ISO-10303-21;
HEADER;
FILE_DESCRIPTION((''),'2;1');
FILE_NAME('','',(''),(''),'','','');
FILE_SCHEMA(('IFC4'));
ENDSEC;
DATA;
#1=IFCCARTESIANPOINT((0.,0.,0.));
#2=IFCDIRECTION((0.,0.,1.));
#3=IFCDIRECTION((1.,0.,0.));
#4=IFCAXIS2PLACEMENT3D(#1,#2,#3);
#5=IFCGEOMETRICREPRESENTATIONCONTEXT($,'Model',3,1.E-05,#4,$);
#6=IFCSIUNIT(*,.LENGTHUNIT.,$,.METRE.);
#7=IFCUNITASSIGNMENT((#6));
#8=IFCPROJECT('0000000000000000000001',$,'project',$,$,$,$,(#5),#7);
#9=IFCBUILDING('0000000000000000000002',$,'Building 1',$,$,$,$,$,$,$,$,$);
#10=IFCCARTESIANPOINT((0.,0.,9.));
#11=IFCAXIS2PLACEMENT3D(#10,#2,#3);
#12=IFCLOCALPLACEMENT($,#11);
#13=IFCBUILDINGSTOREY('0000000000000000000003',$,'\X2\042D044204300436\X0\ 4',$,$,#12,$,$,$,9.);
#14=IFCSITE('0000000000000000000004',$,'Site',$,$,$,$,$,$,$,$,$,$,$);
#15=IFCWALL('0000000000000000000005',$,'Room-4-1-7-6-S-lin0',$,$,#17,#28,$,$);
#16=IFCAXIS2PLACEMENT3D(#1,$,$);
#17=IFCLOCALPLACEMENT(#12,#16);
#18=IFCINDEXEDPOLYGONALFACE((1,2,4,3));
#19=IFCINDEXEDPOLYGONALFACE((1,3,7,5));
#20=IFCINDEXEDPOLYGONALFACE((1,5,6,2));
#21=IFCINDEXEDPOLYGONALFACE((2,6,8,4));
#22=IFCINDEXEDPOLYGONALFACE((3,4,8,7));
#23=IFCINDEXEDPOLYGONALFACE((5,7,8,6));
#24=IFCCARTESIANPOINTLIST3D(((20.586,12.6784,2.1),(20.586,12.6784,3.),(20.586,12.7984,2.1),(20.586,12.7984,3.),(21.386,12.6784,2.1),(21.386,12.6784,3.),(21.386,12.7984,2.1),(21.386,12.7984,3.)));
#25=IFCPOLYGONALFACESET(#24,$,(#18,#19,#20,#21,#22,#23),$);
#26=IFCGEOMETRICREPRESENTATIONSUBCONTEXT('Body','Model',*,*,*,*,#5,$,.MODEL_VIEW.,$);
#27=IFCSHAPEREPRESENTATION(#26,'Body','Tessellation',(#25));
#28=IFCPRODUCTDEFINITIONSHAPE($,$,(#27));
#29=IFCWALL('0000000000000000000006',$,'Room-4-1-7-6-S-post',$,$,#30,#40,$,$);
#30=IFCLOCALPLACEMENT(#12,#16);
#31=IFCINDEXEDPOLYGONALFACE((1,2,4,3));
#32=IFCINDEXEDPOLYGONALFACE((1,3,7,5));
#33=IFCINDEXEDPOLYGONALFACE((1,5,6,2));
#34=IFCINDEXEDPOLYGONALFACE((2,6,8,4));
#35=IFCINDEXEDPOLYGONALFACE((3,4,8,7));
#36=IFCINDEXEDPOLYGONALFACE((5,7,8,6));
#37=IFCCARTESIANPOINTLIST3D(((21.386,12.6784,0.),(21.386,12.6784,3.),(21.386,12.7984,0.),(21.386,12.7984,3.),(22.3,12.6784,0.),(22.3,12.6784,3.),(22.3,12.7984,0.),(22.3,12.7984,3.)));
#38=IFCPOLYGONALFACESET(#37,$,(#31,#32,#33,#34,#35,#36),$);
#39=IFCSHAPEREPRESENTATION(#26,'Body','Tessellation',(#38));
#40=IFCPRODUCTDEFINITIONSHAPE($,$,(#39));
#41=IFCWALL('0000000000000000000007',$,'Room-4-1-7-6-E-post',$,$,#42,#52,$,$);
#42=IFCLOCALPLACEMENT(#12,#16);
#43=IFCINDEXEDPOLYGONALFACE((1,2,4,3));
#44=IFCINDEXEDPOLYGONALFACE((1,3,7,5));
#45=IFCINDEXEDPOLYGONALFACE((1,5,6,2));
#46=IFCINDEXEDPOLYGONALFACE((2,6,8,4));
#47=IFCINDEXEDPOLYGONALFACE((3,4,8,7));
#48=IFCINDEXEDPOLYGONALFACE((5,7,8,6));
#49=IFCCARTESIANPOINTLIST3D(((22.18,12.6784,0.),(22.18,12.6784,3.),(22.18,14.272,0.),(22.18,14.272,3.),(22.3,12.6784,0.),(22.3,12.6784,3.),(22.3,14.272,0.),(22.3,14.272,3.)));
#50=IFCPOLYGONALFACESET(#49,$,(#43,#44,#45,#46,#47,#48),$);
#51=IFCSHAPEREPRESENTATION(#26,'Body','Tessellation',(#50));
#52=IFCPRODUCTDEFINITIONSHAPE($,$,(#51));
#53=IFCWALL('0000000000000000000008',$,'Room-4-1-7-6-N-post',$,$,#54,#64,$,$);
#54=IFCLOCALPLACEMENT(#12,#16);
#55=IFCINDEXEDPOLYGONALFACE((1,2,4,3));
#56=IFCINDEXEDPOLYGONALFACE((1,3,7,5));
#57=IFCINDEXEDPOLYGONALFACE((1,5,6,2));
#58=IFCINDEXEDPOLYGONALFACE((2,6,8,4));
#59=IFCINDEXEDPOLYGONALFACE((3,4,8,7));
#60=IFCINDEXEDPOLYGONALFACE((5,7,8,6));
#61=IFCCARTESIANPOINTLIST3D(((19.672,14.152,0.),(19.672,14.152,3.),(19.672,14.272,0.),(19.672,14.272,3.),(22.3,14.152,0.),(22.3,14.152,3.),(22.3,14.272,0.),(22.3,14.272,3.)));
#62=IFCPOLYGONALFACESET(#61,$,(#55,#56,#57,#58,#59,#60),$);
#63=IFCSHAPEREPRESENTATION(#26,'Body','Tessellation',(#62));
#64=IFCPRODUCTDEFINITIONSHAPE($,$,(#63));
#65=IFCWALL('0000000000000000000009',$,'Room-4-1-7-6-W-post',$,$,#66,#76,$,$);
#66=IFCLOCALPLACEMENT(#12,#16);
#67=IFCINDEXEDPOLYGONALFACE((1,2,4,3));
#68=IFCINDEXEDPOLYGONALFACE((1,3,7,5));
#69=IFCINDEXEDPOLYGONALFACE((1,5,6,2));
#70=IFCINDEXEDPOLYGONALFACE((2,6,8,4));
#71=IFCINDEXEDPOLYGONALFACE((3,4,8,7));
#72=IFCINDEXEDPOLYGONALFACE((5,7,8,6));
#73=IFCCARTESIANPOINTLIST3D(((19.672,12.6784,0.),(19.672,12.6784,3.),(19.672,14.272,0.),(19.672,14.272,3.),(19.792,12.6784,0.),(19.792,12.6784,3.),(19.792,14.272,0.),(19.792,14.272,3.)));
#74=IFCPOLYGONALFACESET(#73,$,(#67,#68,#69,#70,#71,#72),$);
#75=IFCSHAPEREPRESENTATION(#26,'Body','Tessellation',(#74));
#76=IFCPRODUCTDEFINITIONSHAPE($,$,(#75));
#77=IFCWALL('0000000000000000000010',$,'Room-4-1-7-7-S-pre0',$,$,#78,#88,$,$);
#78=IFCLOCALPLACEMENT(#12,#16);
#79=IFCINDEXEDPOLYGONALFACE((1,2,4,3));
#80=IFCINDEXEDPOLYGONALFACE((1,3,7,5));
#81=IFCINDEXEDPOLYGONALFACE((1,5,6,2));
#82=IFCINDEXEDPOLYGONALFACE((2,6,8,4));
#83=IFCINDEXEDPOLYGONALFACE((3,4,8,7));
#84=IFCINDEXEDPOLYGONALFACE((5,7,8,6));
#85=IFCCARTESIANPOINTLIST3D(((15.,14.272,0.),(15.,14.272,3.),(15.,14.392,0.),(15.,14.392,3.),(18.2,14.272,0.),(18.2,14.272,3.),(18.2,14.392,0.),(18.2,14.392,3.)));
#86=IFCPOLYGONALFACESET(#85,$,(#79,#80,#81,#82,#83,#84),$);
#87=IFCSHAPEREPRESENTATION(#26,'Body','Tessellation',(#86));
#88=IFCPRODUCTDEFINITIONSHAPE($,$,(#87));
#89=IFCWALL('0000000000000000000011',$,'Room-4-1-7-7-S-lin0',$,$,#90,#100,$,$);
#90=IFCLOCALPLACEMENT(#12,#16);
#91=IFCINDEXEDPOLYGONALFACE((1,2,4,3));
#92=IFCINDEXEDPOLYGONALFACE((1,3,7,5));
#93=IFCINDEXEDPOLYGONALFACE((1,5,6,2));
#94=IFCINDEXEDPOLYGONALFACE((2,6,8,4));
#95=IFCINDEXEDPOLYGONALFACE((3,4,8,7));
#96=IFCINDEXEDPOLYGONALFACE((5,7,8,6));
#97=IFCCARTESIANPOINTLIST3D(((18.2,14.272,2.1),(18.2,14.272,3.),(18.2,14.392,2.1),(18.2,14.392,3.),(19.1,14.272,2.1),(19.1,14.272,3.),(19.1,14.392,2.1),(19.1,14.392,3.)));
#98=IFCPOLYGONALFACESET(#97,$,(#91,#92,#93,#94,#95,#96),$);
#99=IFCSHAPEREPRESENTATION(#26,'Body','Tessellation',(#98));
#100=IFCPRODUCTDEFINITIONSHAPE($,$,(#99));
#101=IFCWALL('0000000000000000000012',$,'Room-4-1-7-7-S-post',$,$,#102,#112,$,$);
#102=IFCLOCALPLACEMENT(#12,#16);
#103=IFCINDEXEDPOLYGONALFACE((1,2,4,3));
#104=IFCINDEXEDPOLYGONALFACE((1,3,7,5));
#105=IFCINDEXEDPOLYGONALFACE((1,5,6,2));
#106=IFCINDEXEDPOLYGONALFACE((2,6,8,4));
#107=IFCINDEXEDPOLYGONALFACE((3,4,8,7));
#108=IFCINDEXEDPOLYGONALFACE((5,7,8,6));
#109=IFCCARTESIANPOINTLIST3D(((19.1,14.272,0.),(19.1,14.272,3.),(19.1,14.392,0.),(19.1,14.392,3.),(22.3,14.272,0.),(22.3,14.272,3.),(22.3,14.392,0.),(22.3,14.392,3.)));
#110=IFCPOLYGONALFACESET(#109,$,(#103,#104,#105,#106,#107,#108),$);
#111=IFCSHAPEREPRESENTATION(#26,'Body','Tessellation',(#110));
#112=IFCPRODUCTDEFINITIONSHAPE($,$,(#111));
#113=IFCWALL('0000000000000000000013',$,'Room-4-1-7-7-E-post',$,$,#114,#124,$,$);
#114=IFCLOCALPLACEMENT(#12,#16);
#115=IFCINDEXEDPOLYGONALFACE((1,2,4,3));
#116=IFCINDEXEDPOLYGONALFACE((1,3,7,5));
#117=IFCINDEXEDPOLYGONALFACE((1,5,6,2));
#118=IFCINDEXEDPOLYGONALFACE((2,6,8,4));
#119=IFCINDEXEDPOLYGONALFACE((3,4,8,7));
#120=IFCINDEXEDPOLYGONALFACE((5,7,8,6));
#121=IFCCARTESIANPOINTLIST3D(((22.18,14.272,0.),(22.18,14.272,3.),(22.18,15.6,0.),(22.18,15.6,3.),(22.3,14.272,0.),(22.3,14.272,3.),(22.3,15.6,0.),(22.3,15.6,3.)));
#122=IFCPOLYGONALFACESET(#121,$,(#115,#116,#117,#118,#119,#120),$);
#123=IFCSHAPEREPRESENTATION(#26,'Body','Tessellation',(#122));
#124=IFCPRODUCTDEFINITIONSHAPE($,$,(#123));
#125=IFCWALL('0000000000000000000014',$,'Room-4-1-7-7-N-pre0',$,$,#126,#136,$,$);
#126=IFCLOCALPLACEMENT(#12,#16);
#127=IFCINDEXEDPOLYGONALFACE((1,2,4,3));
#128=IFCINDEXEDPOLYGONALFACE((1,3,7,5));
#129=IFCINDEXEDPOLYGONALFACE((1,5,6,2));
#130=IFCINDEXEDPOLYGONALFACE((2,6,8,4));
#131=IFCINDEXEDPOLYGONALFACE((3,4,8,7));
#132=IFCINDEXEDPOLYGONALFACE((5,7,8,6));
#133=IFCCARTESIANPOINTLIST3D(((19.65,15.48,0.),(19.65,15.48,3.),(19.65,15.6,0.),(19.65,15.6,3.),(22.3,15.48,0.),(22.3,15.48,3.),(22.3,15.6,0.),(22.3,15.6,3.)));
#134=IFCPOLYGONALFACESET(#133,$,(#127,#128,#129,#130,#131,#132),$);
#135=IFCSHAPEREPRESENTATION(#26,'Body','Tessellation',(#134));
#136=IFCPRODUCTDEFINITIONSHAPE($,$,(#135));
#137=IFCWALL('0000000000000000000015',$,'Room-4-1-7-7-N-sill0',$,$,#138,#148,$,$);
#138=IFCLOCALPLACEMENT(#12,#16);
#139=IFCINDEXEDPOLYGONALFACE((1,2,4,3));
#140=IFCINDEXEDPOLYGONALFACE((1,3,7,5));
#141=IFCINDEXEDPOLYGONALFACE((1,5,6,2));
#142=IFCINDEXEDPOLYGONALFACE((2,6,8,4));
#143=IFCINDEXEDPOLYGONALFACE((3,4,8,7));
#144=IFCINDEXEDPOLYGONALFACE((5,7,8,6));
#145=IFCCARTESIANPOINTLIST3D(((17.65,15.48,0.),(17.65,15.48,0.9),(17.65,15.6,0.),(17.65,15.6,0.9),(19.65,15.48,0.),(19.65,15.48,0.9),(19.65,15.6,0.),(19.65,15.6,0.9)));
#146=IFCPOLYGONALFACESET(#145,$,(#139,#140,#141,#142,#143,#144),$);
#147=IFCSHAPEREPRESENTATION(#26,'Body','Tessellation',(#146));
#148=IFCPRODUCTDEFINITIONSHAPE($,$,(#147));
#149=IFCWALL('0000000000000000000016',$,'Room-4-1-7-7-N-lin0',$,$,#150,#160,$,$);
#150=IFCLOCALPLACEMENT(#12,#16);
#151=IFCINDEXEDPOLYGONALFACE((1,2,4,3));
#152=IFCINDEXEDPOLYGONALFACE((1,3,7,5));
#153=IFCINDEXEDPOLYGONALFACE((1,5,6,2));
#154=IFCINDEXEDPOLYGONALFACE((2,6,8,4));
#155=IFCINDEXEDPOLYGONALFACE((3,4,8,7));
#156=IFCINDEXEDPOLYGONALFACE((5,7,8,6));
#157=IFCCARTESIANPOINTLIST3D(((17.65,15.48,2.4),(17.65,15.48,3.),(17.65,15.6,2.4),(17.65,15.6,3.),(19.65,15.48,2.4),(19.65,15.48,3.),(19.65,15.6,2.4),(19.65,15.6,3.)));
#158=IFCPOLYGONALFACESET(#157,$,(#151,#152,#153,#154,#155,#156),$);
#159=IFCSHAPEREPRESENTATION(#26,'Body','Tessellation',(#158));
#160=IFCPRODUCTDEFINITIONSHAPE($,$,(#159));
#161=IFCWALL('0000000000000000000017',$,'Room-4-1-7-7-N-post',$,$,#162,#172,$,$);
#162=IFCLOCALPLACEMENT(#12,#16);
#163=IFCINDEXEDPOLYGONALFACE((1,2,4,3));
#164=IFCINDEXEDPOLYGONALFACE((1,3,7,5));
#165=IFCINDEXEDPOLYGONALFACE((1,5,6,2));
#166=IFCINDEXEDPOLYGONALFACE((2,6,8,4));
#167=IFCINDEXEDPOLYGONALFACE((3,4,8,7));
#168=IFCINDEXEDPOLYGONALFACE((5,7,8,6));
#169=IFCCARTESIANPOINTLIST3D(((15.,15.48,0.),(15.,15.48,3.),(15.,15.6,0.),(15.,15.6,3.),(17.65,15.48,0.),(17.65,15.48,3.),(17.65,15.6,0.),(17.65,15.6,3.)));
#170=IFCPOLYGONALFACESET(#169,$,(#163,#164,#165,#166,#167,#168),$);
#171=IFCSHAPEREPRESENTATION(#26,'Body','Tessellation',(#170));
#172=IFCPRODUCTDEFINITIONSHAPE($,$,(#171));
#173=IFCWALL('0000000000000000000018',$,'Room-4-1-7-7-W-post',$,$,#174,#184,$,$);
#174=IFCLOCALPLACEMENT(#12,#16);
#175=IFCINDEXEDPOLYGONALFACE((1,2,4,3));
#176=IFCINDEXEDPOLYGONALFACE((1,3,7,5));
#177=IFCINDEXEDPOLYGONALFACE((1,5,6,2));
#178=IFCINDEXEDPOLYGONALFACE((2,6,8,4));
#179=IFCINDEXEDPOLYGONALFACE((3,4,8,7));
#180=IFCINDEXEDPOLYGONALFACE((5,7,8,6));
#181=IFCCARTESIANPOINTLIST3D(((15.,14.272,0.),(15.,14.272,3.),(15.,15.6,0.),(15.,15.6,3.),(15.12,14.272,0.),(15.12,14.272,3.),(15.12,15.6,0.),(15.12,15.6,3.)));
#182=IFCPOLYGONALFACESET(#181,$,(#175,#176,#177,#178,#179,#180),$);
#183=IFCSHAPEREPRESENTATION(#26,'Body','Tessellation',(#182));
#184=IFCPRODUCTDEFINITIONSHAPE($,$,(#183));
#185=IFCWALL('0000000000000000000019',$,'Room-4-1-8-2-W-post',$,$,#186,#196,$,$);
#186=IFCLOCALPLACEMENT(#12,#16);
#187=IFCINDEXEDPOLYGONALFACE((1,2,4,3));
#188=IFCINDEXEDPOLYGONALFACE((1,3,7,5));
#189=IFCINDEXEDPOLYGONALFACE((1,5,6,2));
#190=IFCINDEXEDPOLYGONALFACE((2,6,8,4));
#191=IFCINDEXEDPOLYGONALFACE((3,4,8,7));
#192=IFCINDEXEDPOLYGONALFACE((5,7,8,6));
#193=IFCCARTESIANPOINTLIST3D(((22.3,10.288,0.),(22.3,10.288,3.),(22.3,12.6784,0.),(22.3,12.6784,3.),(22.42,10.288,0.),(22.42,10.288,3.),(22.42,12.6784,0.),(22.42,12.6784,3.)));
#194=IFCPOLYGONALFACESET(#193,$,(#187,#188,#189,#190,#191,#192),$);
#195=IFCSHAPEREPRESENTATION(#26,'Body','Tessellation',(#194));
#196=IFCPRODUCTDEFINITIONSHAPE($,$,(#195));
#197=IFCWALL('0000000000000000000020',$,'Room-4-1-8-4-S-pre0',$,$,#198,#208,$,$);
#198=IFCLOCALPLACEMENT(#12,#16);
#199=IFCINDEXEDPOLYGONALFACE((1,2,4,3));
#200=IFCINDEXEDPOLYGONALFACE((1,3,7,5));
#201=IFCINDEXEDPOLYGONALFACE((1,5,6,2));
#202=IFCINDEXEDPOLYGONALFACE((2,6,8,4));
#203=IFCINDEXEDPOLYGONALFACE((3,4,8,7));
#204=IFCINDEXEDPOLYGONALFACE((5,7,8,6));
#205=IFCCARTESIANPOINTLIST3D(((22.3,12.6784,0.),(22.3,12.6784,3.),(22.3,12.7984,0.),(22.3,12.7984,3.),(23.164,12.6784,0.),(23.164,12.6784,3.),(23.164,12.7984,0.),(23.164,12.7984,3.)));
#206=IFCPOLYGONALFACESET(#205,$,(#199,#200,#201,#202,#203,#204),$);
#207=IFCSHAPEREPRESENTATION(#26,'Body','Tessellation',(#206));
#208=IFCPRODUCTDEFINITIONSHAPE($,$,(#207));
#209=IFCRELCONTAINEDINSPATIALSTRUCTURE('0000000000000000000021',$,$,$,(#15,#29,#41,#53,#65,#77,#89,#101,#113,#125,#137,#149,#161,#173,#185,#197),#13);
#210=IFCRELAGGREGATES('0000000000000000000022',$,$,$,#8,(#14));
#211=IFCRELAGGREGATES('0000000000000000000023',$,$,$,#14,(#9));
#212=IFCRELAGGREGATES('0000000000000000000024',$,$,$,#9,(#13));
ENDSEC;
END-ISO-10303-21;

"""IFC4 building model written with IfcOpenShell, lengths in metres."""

from ifc_helpers import new_model, si_unit, frame, origin_with_axes, place, context, subcontext, project, spatial, indexed_curve, outline, extrude, element, save


model = new_model("IFC4")

# Units and contexts
model_context = context("Model", 3, precision=1e-05, world=origin_with_axes())
body_context = subcontext(model_context, "Body", "Model", "MODEL_VIEW")
ifc_project = project(units=[si_unit("LENGTHUNIT", "METRE")], contexts=[model_context])

# Site, building, storey
site = spatial("IfcSite", under=ifc_project, Name="Site")
building = spatial("IfcBuilding", under=site, Name="Building 1")
storey_placement = place(None, frame((0.0, 0.0, 9.0), z_axis=(0.0, 0.0, 1.0), x_axis=(1.0, 0.0, 0.0)))
storey = spatial("IfcBuildingStorey", under=building, at=storey_placement, Name="Этаж 4", Elevation=9.0)

# Walls
wall_1_placement = place(storey_placement, frame((20.586, 12.6784, 2.1), z_axis=(0.0, 0.0, 1.0), x_axis=(1.0, 0.0, 0.0)))
element("IfcWall", 1, at=wall_1_placement, inside=storey, Name="Room-4-1-7-6-S-lin0", context=body_context, shape_type="SweptSolid", body=[
    extrude(outline(indexed_curve([(0.0, 0.0), (0.0, 0.12), (0.8, 0.12), (0.8, 0.0), (0.0, 0.0)], self_intersect=False)), origin_with_axes(), (0.0, 0.0, 1.0), 0.9),
])
wall_2_placement = place(storey_placement, frame((21.386, 12.6784, 0.0), z_axis=(0.0, 0.0, 1.0), x_axis=(1.0, 0.0, 0.0)))
element("IfcWall", 2, at=wall_2_placement, inside=storey, Name="Room-4-1-7-6-S-post", context=body_context, shape_type="SweptSolid", body=[
    extrude(outline(indexed_curve([(0.0, 0.0), (0.0, 0.12), (0.914, 0.12), (0.914, 0.0), (0.0, 0.0)], self_intersect=False)), origin_with_axes(), (0.0, 0.0, 1.0), 3.0),
])
wall_3_placement = place(storey_placement, frame((22.3, 12.6784, 0.0), z_axis=(0.0, 0.0, 1.0), x_axis=(0.0, 1.0, 0.0)))
element("IfcWall", 3, at=wall_3_placement, inside=storey, Name="Room-4-1-7-6-E-post", context=body_context, shape_type="SweptSolid", body=[
    extrude(outline(indexed_curve([(0.0, 0.0), (0.0, 0.12), (1.5936, 0.12), (1.5936, 0.0), (0.0, 0.0)], self_intersect=False)), origin_with_axes(), (0.0, 0.0, 1.0), 3.0),
])
wall_4_placement = place(storey_placement, frame((22.3, 14.272, 0.0), z_axis=(0.0, 0.0, 1.0), x_axis=(-1.0, 0.0, 0.0)))
element("IfcWall", 4, at=wall_4_placement, inside=storey, Name="Room-4-1-7-6-N-post", context=body_context, shape_type="SweptSolid", body=[
    extrude(outline(indexed_curve([(0.0, 0.0), (0.0, 0.12), (2.628, 0.12), (2.628, 0.0), (0.0, 0.0)], self_intersect=False)), origin_with_axes(), (0.0, 0.0, 1.0), 3.0),
])
wall_5_placement = place(storey_placement, frame((19.672, 14.272, 0.0), z_axis=(0.0, 0.0, 1.0), x_axis=(0.0, -1.0, 0.0)))
element("IfcWall", 5, at=wall_5_placement, inside=storey, Name="Room-4-1-7-6-W-post", context=body_context, shape_type="SweptSolid", body=[
    extrude(outline(indexed_curve([(0.0, 0.0), (0.0, 0.12), (1.5936, 0.12), (1.5936, 0.0), (0.0, 0.0)], self_intersect=False)), origin_with_axes(), (0.0, 0.0, 1.0), 3.0),
])
wall_6_placement = place(storey_placement, frame((15.0, 14.272, 0.0), z_axis=(0.0, 0.0, 1.0), x_axis=(1.0, 0.0, 0.0)))
element("IfcWall", 6, at=wall_6_placement, inside=storey, Name="Room-4-1-7-7-S-pre0", context=body_context, shape_type="SweptSolid", body=[
    extrude(outline(indexed_curve([(0.0, 0.0), (0.0, 0.12), (3.2, 0.12), (3.2, 0.0), (0.0, 0.0)], self_intersect=False)), origin_with_axes(), (0.0, 0.0, 1.0), 3.0),
])
wall_7_placement = place(storey_placement, frame((18.2, 14.272, 2.1), z_axis=(0.0, 0.0, 1.0), x_axis=(1.0, 0.0, 0.0)))
element("IfcWall", 7, at=wall_7_placement, inside=storey, Name="Room-4-1-7-7-S-lin0", context=body_context, shape_type="SweptSolid", body=[
    extrude(outline(indexed_curve([(0.0, 0.0), (0.0, 0.12), (0.9, 0.12), (0.9, 0.0), (0.0, 0.0)], self_intersect=False)), origin_with_axes(), (0.0, 0.0, 1.0), 0.9),
])
wall_8_placement = place(storey_placement, frame((19.1, 14.272, 0.0), z_axis=(0.0, 0.0, 1.0), x_axis=(1.0, 0.0, 0.0)))
element("IfcWall", 8, at=wall_8_placement, inside=storey, Name="Room-4-1-7-7-S-post", context=body_context, shape_type="SweptSolid", body=[
    extrude(outline(indexed_curve([(0.0, 0.0), (0.0, 0.12), (3.2, 0.12), (3.2, 0.0), (0.0, 0.0)], self_intersect=False)), origin_with_axes(), (0.0, 0.0, 1.0), 3.0),
])
wall_9_placement = place(storey_placement, frame((22.3, 14.272, 0.0), z_axis=(0.0, 0.0, 1.0), x_axis=(0.0, 1.0, 0.0)))
element("IfcWall", 9, at=wall_9_placement, inside=storey, Name="Room-4-1-7-7-E-post", context=body_context, shape_type="SweptSolid", body=[
    extrude(outline(indexed_curve([(0.0, 0.0), (0.0, 0.12), (1.328, 0.12), (1.328, 0.0), (0.0, 0.0)], self_intersect=False)), origin_with_axes(), (0.0, 0.0, 1.0), 3.0),
])
wall_10_placement = place(storey_placement, frame((22.3, 15.6, 0.0), z_axis=(0.0, 0.0, 1.0), x_axis=(-1.0, 0.0, 0.0)))
element("IfcWall", 10, at=wall_10_placement, inside=storey, Name="Room-4-1-7-7-N-pre0", context=body_context, shape_type="SweptSolid", body=[
    extrude(outline(indexed_curve([(0.0, 0.0), (0.0, 0.12), (2.65, 0.12), (2.65, 0.0), (0.0, 0.0)], self_intersect=False)), origin_with_axes(), (0.0, 0.0, 1.0), 3.0),
])
wall_11_placement = place(storey_placement, frame((19.65, 15.6, 0.0), z_axis=(0.0, 0.0, 1.0), x_axis=(-1.0, 0.0, 0.0)))
element("IfcWall", 11, at=wall_11_placement, inside=storey, Name="Room-4-1-7-7-N-sill0", context=body_context, shape_type="SweptSolid", body=[
    extrude(outline(indexed_curve([(0.0, 0.0), (0.0, 0.12), (2.0, 0.12), (2.0, 0.0), (0.0, 0.0)], self_intersect=False)), origin_with_axes(), (0.0, 0.0, 1.0), 0.9),
])
wall_12_placement = place(storey_placement, frame((19.65, 15.6, 2.4), z_axis=(0.0, 0.0, 1.0), x_axis=(-1.0, 0.0, 0.0)))
element("IfcWall", 12, at=wall_12_placement, inside=storey, Name="Room-4-1-7-7-N-lin0", context=body_context, shape_type="SweptSolid", body=[
    extrude(outline(indexed_curve([(0.0, 0.0), (0.0, 0.12), (2.0, 0.12), (2.0, 0.0), (0.0, 0.0)], self_intersect=False)), origin_with_axes(), (0.0, 0.0, 1.0), 0.6),
])
wall_13_placement = place(storey_placement, frame((17.65, 15.6, 0.0), z_axis=(0.0, 0.0, 1.0), x_axis=(-1.0, 0.0, 0.0)))
element("IfcWall", 13, at=wall_13_placement, inside=storey, Name="Room-4-1-7-7-N-post", context=body_context, shape_type="SweptSolid", body=[
    extrude(outline(indexed_curve([(0.0, 0.0), (0.0, 0.12), (2.65, 0.12), (2.65, 0.0), (0.0, 0.0)], self_intersect=False)), origin_with_axes(), (0.0, 0.0, 1.0), 3.0),
])
wall_14_placement = place(storey_placement, frame((15.0, 15.6, 0.0), z_axis=(0.0, 0.0, 1.0), x_axis=(0.0, -1.0, 0.0)))
element("IfcWall", 14, at=wall_14_placement, inside=storey, Name="Room-4-1-7-7-W-post", context=body_context, shape_type="SweptSolid", body=[
    extrude(outline(indexed_curve([(0.0, 0.0), (0.0, 0.12), (1.328, 0.12), (1.328, 0.0), (0.0, 0.0)], self_intersect=False)), origin_with_axes(), (0.0, 0.0, 1.0), 3.0),
])
wall_15_placement = place(storey_placement, frame((22.3, 12.6784, 0.0), z_axis=(0.0, 0.0, 1.0), x_axis=(0.0, -1.0, 0.0)))
element("IfcWall", 15, at=wall_15_placement, inside=storey, Name="Room-4-1-8-2-W-post", context=body_context, shape_type="SweptSolid", body=[
    extrude(outline(indexed_curve([(0.0, 0.0), (0.0, 0.12), (2.3904, 0.12), (2.3904, 0.0), (0.0, 0.0)], self_intersect=False)), origin_with_axes(), (0.0, 0.0, 1.0), 3.0),
])
wall_16_placement = place(storey_placement, frame((22.3, 12.6784, 0.0), z_axis=(0.0, 0.0, 1.0), x_axis=(1.0, 0.0, 0.0)))
element("IfcWall", 16, at=wall_16_placement, inside=storey, Name="Room-4-1-8-4-S-pre0", context=body_context, shape_type="SweptSolid", body=[
    extrude(outline(indexed_curve([(0.0, 0.0), (0.0, 0.12), (0.864, 0.12), (0.864, 0.0), (0.0, 0.0)], self_intersect=False)), origin_with_axes(), (0.0, 0.0, 1.0), 3.0),
])

save(model, "model.ifc")
